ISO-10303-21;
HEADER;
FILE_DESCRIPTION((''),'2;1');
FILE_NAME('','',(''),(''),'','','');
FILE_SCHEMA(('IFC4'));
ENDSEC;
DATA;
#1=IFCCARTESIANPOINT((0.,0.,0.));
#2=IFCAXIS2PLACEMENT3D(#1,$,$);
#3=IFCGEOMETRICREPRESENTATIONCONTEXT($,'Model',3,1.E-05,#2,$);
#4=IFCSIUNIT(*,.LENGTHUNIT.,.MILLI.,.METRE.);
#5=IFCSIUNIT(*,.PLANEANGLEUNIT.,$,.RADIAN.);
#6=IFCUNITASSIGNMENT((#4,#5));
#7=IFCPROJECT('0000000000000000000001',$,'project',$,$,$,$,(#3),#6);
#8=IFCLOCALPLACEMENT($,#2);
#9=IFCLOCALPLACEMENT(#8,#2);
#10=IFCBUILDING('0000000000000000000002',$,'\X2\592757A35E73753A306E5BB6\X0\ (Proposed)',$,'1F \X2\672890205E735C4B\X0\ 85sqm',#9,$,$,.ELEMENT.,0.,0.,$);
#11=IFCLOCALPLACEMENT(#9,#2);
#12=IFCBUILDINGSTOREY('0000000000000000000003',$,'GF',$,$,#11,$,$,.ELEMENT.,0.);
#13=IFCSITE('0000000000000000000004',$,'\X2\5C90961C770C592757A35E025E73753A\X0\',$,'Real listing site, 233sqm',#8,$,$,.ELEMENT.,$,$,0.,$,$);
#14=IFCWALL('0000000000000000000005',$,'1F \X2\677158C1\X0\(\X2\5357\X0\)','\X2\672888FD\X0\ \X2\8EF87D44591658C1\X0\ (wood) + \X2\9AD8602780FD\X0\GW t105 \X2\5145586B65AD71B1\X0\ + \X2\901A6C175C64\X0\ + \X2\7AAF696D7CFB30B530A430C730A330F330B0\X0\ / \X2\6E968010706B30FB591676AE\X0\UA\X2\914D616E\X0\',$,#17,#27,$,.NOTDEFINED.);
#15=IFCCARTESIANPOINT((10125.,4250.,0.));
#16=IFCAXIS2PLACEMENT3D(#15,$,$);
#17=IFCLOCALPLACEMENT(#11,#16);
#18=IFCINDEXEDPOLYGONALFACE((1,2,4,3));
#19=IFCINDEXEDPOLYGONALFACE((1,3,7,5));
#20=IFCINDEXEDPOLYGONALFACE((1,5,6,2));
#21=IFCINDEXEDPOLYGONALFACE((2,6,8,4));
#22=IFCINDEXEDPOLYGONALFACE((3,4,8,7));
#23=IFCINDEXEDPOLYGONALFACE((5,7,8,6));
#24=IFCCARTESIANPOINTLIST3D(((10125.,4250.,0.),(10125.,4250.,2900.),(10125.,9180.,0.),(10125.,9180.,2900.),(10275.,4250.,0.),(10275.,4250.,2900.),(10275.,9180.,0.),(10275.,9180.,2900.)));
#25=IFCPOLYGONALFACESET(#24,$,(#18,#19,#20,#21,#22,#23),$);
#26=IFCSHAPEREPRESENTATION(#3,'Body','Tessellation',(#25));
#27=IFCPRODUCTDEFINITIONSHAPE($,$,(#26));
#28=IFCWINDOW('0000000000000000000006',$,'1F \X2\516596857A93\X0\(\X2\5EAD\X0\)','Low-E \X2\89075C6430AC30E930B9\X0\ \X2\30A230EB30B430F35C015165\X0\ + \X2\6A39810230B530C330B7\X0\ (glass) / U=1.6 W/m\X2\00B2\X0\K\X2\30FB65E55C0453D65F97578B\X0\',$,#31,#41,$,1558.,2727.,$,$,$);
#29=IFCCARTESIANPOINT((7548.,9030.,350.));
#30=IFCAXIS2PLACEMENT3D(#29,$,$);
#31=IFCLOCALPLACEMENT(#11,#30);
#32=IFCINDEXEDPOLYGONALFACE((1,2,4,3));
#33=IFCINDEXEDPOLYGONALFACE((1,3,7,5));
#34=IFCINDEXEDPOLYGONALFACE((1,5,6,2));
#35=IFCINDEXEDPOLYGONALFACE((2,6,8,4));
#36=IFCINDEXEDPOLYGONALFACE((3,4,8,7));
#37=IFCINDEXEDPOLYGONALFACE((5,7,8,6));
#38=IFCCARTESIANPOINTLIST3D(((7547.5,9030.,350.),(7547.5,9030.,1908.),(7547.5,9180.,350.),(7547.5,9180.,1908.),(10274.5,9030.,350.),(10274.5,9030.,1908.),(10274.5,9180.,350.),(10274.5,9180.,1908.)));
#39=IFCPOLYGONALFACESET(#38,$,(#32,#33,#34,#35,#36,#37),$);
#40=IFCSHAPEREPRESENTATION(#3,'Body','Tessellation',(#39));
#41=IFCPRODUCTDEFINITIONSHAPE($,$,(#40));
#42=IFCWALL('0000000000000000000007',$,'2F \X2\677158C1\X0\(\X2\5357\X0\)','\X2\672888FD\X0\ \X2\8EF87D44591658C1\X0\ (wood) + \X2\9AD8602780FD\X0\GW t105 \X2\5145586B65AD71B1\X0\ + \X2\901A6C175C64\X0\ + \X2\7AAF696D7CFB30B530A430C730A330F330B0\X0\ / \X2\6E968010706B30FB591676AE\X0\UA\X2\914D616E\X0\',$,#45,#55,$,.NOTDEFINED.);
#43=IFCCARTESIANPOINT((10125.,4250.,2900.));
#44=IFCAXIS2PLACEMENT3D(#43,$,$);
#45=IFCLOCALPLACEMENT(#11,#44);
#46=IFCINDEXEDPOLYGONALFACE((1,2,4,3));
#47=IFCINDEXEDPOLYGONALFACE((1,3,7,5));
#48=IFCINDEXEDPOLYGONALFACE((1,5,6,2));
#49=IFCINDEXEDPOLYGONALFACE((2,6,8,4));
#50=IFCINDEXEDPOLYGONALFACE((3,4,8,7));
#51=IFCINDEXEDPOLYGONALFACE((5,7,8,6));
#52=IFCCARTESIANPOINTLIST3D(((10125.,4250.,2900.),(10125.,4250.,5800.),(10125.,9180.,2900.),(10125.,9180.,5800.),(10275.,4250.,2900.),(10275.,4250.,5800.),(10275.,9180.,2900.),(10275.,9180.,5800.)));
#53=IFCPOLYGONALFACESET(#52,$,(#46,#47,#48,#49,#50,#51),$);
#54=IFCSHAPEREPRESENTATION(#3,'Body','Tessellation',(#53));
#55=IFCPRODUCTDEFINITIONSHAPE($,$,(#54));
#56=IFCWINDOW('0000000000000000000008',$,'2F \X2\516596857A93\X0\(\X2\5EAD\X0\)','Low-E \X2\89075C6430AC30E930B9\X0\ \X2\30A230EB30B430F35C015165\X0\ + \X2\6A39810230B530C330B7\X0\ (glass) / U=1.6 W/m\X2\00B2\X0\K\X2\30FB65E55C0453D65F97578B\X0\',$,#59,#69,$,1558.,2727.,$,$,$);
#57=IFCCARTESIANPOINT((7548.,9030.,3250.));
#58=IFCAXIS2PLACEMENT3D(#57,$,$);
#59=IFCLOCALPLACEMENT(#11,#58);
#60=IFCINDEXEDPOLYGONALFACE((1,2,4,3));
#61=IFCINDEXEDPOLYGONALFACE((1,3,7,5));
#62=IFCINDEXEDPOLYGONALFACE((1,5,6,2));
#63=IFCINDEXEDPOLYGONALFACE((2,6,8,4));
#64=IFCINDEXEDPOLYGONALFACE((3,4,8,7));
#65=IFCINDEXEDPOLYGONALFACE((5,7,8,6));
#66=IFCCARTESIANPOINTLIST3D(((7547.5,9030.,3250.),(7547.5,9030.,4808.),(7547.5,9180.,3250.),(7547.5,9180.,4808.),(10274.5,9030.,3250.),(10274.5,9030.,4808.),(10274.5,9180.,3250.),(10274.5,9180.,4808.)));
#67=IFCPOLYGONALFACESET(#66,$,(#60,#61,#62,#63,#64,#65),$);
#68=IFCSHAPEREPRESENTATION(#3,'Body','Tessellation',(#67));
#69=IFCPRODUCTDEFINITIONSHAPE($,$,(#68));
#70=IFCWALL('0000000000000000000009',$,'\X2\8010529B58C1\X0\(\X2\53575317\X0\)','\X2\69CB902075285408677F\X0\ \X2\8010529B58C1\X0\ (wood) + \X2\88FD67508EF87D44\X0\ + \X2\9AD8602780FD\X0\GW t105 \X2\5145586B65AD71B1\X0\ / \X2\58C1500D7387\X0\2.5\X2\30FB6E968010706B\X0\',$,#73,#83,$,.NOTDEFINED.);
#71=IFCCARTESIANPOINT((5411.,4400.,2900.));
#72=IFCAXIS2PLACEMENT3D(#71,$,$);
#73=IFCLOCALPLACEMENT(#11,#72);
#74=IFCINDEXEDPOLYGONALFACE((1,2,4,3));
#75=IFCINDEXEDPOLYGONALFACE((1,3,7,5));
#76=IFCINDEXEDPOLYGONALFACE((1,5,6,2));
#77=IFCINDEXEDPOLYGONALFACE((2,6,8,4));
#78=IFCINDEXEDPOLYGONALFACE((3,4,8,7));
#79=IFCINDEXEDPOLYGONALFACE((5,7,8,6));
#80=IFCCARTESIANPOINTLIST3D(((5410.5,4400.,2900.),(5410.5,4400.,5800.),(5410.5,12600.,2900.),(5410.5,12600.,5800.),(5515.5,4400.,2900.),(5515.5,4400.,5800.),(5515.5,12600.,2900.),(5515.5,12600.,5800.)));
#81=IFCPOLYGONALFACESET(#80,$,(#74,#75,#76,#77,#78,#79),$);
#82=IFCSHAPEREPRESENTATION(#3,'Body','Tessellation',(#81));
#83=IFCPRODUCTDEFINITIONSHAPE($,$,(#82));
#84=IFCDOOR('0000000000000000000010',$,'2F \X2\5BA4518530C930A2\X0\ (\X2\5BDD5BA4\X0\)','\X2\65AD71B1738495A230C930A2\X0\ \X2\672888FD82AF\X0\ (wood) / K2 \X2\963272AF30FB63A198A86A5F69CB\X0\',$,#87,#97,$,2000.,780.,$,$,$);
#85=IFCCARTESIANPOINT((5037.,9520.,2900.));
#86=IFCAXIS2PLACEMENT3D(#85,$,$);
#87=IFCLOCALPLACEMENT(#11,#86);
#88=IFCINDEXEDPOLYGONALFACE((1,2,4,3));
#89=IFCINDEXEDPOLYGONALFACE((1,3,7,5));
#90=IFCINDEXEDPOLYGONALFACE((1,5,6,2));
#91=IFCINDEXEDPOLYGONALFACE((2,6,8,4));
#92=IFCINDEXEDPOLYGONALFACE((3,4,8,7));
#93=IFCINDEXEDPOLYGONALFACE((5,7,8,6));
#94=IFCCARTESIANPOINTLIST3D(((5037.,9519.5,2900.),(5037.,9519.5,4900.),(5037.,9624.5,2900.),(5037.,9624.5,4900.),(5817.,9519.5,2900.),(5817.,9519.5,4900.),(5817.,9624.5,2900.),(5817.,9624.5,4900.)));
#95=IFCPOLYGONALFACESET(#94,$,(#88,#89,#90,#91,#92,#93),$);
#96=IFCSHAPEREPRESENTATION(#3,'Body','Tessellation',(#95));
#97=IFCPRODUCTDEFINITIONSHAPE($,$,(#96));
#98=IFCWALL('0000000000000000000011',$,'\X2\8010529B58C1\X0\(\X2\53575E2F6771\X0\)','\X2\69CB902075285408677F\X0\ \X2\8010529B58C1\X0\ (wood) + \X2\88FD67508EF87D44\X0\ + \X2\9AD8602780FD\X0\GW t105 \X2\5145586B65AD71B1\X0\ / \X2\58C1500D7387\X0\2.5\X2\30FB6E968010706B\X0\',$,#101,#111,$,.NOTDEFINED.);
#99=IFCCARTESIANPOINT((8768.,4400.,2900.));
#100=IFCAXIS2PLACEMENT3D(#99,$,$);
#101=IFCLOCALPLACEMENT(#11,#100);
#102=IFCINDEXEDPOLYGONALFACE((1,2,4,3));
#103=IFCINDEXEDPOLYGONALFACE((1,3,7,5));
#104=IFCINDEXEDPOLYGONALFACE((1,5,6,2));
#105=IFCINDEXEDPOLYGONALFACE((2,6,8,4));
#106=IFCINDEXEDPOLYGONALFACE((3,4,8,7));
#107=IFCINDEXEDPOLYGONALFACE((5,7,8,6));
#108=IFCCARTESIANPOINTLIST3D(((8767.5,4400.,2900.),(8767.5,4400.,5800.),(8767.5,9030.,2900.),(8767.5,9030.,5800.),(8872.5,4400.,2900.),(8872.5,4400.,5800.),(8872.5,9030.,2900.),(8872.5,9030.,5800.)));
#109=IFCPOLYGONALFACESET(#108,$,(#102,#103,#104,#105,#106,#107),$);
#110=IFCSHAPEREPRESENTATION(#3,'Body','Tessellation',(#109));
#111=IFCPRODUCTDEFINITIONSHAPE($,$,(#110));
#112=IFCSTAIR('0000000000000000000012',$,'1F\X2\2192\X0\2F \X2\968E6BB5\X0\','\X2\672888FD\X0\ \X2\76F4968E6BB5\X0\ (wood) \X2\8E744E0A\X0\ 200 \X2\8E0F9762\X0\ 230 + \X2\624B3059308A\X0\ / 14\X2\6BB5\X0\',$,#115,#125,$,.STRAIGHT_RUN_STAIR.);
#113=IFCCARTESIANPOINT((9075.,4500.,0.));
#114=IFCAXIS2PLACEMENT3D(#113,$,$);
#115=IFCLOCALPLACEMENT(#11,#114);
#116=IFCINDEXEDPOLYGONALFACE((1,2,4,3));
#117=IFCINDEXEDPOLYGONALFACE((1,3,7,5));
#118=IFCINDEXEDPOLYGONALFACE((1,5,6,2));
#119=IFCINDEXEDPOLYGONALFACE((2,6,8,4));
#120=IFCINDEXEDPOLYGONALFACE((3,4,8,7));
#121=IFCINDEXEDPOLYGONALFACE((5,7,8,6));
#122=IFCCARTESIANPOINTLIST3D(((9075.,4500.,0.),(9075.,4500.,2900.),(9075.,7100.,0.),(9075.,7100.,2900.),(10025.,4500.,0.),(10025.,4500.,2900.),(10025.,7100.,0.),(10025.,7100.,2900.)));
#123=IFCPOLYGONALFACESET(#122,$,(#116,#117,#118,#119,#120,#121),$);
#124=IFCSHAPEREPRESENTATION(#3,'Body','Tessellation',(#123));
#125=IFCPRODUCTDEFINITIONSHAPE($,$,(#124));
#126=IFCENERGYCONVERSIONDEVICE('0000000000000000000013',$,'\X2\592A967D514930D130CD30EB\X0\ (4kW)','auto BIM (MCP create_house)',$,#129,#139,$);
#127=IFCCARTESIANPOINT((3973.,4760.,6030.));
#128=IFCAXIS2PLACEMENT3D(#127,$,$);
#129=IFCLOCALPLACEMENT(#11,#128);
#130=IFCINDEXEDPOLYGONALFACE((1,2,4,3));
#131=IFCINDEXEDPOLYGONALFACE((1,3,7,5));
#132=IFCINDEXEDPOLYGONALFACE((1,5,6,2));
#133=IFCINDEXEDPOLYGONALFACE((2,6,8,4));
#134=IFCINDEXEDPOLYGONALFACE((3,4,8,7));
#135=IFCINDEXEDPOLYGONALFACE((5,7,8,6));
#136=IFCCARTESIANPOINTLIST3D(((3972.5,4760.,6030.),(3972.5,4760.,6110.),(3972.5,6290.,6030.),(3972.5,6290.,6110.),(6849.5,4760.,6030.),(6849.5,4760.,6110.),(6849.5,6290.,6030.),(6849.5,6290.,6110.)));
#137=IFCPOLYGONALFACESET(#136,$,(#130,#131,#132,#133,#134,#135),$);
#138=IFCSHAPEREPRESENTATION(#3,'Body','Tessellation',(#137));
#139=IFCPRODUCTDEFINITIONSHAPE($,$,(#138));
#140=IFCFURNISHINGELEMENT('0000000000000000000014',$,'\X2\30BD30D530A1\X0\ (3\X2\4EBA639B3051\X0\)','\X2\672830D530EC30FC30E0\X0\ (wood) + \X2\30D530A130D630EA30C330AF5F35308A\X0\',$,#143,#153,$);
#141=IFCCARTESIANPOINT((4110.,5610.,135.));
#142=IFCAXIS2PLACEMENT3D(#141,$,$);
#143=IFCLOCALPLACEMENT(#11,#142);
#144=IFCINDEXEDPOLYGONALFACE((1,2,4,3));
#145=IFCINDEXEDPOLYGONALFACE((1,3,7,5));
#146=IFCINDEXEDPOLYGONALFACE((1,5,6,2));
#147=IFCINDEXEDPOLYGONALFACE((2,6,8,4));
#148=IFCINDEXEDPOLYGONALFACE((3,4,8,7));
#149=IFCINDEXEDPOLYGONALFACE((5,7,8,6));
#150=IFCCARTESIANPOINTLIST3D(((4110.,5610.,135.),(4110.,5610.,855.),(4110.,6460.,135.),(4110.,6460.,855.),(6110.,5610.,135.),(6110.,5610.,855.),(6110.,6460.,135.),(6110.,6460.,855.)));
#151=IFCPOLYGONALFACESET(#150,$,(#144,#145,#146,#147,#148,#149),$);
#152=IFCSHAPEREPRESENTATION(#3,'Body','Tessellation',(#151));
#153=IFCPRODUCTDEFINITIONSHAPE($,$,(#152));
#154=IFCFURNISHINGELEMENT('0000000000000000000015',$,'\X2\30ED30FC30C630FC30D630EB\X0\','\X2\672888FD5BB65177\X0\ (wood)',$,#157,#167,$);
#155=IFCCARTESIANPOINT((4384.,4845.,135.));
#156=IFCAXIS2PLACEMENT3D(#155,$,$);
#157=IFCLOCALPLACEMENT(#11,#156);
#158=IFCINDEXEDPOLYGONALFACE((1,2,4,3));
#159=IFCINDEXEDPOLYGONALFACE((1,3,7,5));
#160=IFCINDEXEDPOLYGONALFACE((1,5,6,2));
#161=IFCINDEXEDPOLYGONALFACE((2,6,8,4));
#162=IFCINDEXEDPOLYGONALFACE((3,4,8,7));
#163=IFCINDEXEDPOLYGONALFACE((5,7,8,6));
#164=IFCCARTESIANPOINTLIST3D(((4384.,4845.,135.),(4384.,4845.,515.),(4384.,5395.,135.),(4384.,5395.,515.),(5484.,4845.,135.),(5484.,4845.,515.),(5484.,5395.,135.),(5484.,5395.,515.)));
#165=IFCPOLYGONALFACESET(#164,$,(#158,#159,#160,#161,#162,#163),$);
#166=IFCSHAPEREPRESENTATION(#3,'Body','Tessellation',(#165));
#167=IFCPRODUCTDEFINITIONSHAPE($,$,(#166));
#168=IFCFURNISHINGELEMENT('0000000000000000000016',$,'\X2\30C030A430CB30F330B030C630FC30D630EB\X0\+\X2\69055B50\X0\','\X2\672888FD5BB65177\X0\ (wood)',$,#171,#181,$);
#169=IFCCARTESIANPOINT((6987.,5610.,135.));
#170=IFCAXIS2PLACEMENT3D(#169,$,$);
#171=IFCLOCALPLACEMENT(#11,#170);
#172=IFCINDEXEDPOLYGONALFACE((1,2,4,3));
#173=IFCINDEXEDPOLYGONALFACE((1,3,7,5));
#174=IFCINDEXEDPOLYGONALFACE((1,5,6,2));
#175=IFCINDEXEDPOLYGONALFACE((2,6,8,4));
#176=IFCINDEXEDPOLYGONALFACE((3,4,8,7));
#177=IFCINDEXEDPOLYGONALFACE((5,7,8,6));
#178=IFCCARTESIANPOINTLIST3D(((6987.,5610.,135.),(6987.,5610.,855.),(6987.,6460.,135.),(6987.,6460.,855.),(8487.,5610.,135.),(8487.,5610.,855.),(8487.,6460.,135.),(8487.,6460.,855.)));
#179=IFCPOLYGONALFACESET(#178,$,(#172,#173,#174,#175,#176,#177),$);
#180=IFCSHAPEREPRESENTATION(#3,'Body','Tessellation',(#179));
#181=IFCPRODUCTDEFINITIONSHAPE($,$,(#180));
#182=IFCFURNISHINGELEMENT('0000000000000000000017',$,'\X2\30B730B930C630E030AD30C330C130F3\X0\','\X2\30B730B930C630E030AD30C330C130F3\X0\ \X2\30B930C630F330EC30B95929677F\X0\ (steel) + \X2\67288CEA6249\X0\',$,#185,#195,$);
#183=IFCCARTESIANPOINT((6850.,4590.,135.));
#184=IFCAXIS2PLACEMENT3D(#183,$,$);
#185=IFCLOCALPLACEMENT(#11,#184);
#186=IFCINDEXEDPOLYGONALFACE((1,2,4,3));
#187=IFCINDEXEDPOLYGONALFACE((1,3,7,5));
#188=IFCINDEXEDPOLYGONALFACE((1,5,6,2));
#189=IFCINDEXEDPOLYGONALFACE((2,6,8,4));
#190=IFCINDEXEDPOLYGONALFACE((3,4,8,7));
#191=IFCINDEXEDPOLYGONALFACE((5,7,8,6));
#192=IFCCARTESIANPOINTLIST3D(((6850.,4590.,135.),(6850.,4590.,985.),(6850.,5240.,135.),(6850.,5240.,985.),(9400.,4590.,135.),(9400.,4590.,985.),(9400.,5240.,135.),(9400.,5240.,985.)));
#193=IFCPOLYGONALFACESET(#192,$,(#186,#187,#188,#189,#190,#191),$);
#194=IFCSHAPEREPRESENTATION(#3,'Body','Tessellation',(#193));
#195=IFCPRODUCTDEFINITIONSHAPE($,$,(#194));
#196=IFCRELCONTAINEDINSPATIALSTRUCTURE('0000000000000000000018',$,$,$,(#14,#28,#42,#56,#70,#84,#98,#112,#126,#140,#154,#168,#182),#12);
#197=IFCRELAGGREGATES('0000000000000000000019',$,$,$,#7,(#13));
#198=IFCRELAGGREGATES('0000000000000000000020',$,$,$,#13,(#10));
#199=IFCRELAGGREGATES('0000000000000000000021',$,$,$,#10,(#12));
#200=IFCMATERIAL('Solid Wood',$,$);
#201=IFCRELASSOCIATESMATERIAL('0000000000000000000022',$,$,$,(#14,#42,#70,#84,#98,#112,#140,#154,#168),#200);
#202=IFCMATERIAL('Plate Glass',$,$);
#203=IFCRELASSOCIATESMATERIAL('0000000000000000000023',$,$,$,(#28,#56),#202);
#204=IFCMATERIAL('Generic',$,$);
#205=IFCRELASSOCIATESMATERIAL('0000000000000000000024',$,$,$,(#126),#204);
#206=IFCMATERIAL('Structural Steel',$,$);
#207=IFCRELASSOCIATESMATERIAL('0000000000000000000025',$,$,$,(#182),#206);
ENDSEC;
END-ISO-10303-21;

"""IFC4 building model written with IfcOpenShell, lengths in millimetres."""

from ifc_helpers import new_model, si_unit, frame, frame_2d, origin, place, context, project, spatial, rectangle, extrude, material, element, fill, save


model = new_model("IFC4")

# Units and contexts
model_context = context("Model", 3, precision=1e-05, world=origin())
ifc_project = project(units=[si_unit("LENGTHUNIT", "METRE", prefix="MILLI"), si_unit("PLANEANGLEUNIT", "RADIAN")], contexts=[model_context])

# Site, building, storey
site_placement = place(None, origin())
site = spatial("IfcSite", under=ifc_project, at=site_placement, Name="岐阜県大垣市平町", ObjectType="Real listing site, 233sqm", CompositionType="ELEMENT", RefElevation=0.0)
building_placement = place(site_placement, origin())
building = spatial("IfcBuilding", under=site, at=building_placement, Name="大垣平町の家 (Proposed)", ObjectType="1F 木造平屋 85sqm", CompositionType="ELEMENT", ElevationOfRefHeight=0.0, ElevationOfTerrain=0.0)
storey_placement = place(building_placement, origin())
storey = spatial("IfcBuildingStorey", under=building, at=storey_placement, Name="GF", CompositionType="ELEMENT", Elevation=0.0)

# Wall, opening, window
ifc_material_1 = material(Name="Solid Wood")
wall_1_placement = place(storey_placement, frame((10125.0, 4250.0, 0.0)))
wall_1 = element("IfcWall", 1, at=wall_1_placement, inside=storey, material=ifc_material_1, Name="1F 東壁(南)", Description="木製 軸組外壁 (wood) + 高性能GW t105 充填断熱 + 通気層 + 窯業系サイディング / 準耐火・外皮UA配慮", PredefinedType="NOTDEFINED", context=model_context, shape_type="SweptSolid", body=[
    extrude(rectangle(XDim=150.0, YDim=4930.0, at=frame_2d((75.0, 2465.0))), frame((10125.0, 4250.0, 0.0)), (0.0, 0.0, 1.0), 2900.0),
])
opening_1_placement = place(storey_placement, frame((7548.0, 9030.0, 350.0)))
opening_1 = element("IfcOpeningElement", 2, at=opening_1_placement, cuts=wall_1, PredefinedType="NOTDEFINED", context=model_context, shape_type="SweptSolid", body=[
    extrude(rectangle(XDim=2727.0, YDim=150.0, at=frame_2d((1363.0, 75.0))), frame((7548.0, 9030.0, 350.0)), (0.0, 0.0, 1.0), 1558.0),
])
ifc_material_2 = material(Name="Plate Glass")
window_1_placement = place(storey_placement, frame((7548.0, 9030.0, 350.0)))
window_1 = element("IfcWindow", 3, at=window_1_placement, inside=storey, material=ifc_material_2, Name="1F 入隅窓(庭)", Description="Low-E 複層ガラス アルゴン封入 + 樹脂サッシ (glass) / U=1.6 W/m²K・日射取得型", OverallHeight=1558.0, OverallWidth=2727.0, context=model_context, shape_type="SweptSolid", body=[
    extrude(rectangle(XDim=2727.0, YDim=150.0, at=frame_2d((1363.0, 75.0))), frame((7548.0, 9030.0, 350.0)), (0.0, 0.0, 1.0), 1558.0),
])
fill(opening_1, window_1)

# Wall, opening, window
wall_2_placement = place(storey_placement, frame((10125.0, 4250.0, 2900.0)))
wall_2 = element("IfcWall", 4, at=wall_2_placement, inside=storey, material=ifc_material_1, Name="2F 東壁(南)", Description="木製 軸組外壁 (wood) + 高性能GW t105 充填断熱 + 通気層 + 窯業系サイディング / 準耐火・外皮UA配慮", PredefinedType="NOTDEFINED", context=model_context, shape_type="SweptSolid", body=[
    extrude(rectangle(XDim=150.0, YDim=4930.0, at=frame_2d((75.0, 2465.0))), frame((10125.0, 4250.0, 2900.0)), (0.0, 0.0, 1.0), 2900.0),
])
opening_2_placement = place(storey_placement, frame((7548.0, 9030.0, 3250.0)))
opening_2 = element("IfcOpeningElement", 5, at=opening_2_placement, cuts=wall_2, PredefinedType="NOTDEFINED", context=model_context, shape_type="SweptSolid", body=[
    extrude(rectangle(XDim=2727.0, YDim=150.0, at=frame_2d((1363.0, 75.0))), frame((7548.0, 9030.0, 3250.0)), (0.0, 0.0, 1.0), 1558.0),
])
window_2_placement = place(storey_placement, frame((7548.0, 9030.0, 3250.0)))
window_2 = element("IfcWindow", 6, at=window_2_placement, inside=storey, material=ifc_material_2, Name="2F 入隅窓(庭)", Description="Low-E 複層ガラス アルゴン封入 + 樹脂サッシ (glass) / U=1.6 W/m²K・日射取得型", OverallHeight=1558.0, OverallWidth=2727.0, context=model_context, shape_type="SweptSolid", body=[
    extrude(rectangle(XDim=2727.0, YDim=150.0, at=frame_2d((1363.0, 75.0))), frame((7548.0, 9030.0, 3250.0)), (0.0, 0.0, 1.0), 1558.0),
])
fill(opening_2, window_2)

# Wall, opening, door
wall_3_placement = place(storey_placement, frame((5411.0, 4400.0, 2900.0)))
wall_3 = element("IfcWall", 7, at=wall_3_placement, inside=storey, material=ifc_material_1, Name="耐力壁(南北)", Description="構造用合板 耐力壁 (wood) + 製材軸組 + 高性能GW t105 充填断熱 / 壁倍率2.5・準耐火", PredefinedType="NOTDEFINED", context=model_context, shape_type="SweptSolid", body=[
    extrude(rectangle(XDim=105.0, YDim=8200.0, at=frame_2d((52.0, 4100.0))), frame((5411.0, 4400.0, 2900.0)), (0.0, 0.0, 1.0), 2900.0),
])
opening_3_placement = place(storey_placement, frame((5037.0, 9520.0, 2900.0)))
opening_3 = element("IfcOpeningElement", 8, at=opening_3_placement, cuts=wall_3, PredefinedType="NOTDEFINED", context=model_context, shape_type="SweptSolid", body=[
    extrude(rectangle(XDim=780.0, YDim=105.0, at=frame_2d((390.0, 52.0))), frame((5037.0, 9520.0, 2900.0)), (0.0, 0.0, 1.0), 2000.0),
])
door_1_placement = place(storey_placement, frame((5037.0, 9520.0, 2900.0)))
door_1 = element("IfcDoor", 9, at=door_1_placement, inside=storey, material=ifc_material_1, Name="2F 室内ドア (寝室)", Description="断熱玄関ドア 木製芯 (wood) / K2 防犯・採風機構", OverallHeight=2000.0, OverallWidth=780.0, context=model_context, shape_type="SweptSolid", body=[
    extrude(rectangle(XDim=780.0, YDim=105.0, at=frame_2d((390.0, 52.0))), frame((5037.0, 9520.0, 2900.0)), (0.0, 0.0, 1.0), 2000.0),
])
fill(opening_3, door_1)

# Wall
wall_4_placement = place(storey_placement, frame((8768.0, 4400.0, 2900.0)))
element("IfcWall", 10, at=wall_4_placement, inside=storey, material=ifc_material_1, Name="耐力壁(南帯東)", Description="構造用合板 耐力壁 (wood) + 製材軸組 + 高性能GW t105 充填断熱 / 壁倍率2.5・準耐火", PredefinedType="NOTDEFINED", context=model_context, shape_type="SweptSolid", body=[
    extrude(rectangle(XDim=105.0, YDim=4630.0, at=frame_2d((52.0, 2315.0))), frame((8768.0, 4400.0, 2900.0)), (0.0, 0.0, 1.0), 2900.0),
])

# Stair
stair_placement = place(storey_placement, frame((9075.0, 4500.0, 0.0)))
element("IfcStair", 11, at=stair_placement, inside=storey, material=ifc_material_1, Name="1F→2F 階段", Description="木製 直階段 (wood) 蹴上 200 踏面 230 + 手すり / 14段", PredefinedType="STRAIGHT_RUN_STAIR", context=model_context, shape_type="SweptSolid", body=[
    extrude(rectangle(XDim=950.0, YDim=2600.0, at=frame_2d((475.0, 1300.0))), frame((9075.0, 4500.0, 0.0)), (0.0, 0.0, 1.0), 2900.0),
])

# Energy conversion device
ifc_material_3 = material(Name="Generic")
energy_conversion_device_placement = place(storey_placement, frame((3973.0, 4760.0, 6030.0)))
element("IfcEnergyConversionDevice", 12, at=energy_conversion_device_placement, inside=storey, material=ifc_material_3, Name="太陽光パネル (4kW)", Description="auto BIM (MCP create_house)", context=model_context, shape_type="SweptSolid", body=[
    extrude(rectangle(XDim=2877.0, YDim=1530.0, at=frame_2d((1438.0, 765.0))), frame((3973.0, 4760.0, 6030.0)), (0.0, 0.0, 1.0), 80.0),
])

# Furnishing elements
furnishing_1_placement = place(storey_placement, frame((4110.0, 5610.0, 135.0)))
element("IfcFurnishingElement", 13, at=furnishing_1_placement, inside=storey, material=ifc_material_1, Name="ソファ (3人掛け)", Description="木フレーム (wood) + ファブリック張り", context=model_context, shape_type="SweptSolid", body=[
    extrude(rectangle(XDim=2000.0, YDim=850.0, at=frame_2d((1000.0, 425.0))), frame((4110.0, 5610.0, 135.0)), (0.0, 0.0, 1.0), 720.0),
])
furnishing_2_placement = place(storey_placement, frame((4384.0, 4845.0, 135.0)))
element("IfcFurnishingElement", 14, at=furnishing_2_placement, inside=storey, material=ifc_material_1, Name="ローテーブル", Description="木製家具 (wood)", context=model_context, shape_type="SweptSolid", body=[
    extrude(rectangle(XDim=1100.0, YDim=550.0, at=frame_2d((550.0, 275.0))), frame((4384.0, 4845.0, 135.0)), (0.0, 0.0, 1.0), 380.0),
])
furnishing_3_placement = place(storey_placement, frame((6987.0, 5610.0, 135.0)))
element("IfcFurnishingElement", 15, at=furnishing_3_placement, inside=storey, material=ifc_material_1, Name="ダイニングテーブル+椅子", Description="木製家具 (wood)", context=model_context, shape_type="SweptSolid", body=[
    extrude(rectangle(XDim=1500.0, YDim=850.0, at=frame_2d((750.0, 425.0))), frame((6987.0, 5610.0, 135.0)), (0.0, 0.0, 1.0), 720.0),
])
ifc_material_4 = material(Name="Structural Steel")
furnishing_4_placement = place(storey_placement, frame((6850.0, 4590.0, 135.0)))
element("IfcFurnishingElement", 16, at=furnishing_4_placement, inside=storey, material=ifc_material_4, Name="システムキッチン", Description="システムキッチン ステンレス天板 (steel) + 木質扉", context=model_context, shape_type="SweptSolid", body=[
    extrude(rectangle(XDim=2550.0, YDim=650.0, at=frame_2d((1275.0, 325.0))), frame((6850.0, 4590.0, 135.0)), (0.0, 0.0, 1.0), 850.0),
])

save(model, "model.ifc")
